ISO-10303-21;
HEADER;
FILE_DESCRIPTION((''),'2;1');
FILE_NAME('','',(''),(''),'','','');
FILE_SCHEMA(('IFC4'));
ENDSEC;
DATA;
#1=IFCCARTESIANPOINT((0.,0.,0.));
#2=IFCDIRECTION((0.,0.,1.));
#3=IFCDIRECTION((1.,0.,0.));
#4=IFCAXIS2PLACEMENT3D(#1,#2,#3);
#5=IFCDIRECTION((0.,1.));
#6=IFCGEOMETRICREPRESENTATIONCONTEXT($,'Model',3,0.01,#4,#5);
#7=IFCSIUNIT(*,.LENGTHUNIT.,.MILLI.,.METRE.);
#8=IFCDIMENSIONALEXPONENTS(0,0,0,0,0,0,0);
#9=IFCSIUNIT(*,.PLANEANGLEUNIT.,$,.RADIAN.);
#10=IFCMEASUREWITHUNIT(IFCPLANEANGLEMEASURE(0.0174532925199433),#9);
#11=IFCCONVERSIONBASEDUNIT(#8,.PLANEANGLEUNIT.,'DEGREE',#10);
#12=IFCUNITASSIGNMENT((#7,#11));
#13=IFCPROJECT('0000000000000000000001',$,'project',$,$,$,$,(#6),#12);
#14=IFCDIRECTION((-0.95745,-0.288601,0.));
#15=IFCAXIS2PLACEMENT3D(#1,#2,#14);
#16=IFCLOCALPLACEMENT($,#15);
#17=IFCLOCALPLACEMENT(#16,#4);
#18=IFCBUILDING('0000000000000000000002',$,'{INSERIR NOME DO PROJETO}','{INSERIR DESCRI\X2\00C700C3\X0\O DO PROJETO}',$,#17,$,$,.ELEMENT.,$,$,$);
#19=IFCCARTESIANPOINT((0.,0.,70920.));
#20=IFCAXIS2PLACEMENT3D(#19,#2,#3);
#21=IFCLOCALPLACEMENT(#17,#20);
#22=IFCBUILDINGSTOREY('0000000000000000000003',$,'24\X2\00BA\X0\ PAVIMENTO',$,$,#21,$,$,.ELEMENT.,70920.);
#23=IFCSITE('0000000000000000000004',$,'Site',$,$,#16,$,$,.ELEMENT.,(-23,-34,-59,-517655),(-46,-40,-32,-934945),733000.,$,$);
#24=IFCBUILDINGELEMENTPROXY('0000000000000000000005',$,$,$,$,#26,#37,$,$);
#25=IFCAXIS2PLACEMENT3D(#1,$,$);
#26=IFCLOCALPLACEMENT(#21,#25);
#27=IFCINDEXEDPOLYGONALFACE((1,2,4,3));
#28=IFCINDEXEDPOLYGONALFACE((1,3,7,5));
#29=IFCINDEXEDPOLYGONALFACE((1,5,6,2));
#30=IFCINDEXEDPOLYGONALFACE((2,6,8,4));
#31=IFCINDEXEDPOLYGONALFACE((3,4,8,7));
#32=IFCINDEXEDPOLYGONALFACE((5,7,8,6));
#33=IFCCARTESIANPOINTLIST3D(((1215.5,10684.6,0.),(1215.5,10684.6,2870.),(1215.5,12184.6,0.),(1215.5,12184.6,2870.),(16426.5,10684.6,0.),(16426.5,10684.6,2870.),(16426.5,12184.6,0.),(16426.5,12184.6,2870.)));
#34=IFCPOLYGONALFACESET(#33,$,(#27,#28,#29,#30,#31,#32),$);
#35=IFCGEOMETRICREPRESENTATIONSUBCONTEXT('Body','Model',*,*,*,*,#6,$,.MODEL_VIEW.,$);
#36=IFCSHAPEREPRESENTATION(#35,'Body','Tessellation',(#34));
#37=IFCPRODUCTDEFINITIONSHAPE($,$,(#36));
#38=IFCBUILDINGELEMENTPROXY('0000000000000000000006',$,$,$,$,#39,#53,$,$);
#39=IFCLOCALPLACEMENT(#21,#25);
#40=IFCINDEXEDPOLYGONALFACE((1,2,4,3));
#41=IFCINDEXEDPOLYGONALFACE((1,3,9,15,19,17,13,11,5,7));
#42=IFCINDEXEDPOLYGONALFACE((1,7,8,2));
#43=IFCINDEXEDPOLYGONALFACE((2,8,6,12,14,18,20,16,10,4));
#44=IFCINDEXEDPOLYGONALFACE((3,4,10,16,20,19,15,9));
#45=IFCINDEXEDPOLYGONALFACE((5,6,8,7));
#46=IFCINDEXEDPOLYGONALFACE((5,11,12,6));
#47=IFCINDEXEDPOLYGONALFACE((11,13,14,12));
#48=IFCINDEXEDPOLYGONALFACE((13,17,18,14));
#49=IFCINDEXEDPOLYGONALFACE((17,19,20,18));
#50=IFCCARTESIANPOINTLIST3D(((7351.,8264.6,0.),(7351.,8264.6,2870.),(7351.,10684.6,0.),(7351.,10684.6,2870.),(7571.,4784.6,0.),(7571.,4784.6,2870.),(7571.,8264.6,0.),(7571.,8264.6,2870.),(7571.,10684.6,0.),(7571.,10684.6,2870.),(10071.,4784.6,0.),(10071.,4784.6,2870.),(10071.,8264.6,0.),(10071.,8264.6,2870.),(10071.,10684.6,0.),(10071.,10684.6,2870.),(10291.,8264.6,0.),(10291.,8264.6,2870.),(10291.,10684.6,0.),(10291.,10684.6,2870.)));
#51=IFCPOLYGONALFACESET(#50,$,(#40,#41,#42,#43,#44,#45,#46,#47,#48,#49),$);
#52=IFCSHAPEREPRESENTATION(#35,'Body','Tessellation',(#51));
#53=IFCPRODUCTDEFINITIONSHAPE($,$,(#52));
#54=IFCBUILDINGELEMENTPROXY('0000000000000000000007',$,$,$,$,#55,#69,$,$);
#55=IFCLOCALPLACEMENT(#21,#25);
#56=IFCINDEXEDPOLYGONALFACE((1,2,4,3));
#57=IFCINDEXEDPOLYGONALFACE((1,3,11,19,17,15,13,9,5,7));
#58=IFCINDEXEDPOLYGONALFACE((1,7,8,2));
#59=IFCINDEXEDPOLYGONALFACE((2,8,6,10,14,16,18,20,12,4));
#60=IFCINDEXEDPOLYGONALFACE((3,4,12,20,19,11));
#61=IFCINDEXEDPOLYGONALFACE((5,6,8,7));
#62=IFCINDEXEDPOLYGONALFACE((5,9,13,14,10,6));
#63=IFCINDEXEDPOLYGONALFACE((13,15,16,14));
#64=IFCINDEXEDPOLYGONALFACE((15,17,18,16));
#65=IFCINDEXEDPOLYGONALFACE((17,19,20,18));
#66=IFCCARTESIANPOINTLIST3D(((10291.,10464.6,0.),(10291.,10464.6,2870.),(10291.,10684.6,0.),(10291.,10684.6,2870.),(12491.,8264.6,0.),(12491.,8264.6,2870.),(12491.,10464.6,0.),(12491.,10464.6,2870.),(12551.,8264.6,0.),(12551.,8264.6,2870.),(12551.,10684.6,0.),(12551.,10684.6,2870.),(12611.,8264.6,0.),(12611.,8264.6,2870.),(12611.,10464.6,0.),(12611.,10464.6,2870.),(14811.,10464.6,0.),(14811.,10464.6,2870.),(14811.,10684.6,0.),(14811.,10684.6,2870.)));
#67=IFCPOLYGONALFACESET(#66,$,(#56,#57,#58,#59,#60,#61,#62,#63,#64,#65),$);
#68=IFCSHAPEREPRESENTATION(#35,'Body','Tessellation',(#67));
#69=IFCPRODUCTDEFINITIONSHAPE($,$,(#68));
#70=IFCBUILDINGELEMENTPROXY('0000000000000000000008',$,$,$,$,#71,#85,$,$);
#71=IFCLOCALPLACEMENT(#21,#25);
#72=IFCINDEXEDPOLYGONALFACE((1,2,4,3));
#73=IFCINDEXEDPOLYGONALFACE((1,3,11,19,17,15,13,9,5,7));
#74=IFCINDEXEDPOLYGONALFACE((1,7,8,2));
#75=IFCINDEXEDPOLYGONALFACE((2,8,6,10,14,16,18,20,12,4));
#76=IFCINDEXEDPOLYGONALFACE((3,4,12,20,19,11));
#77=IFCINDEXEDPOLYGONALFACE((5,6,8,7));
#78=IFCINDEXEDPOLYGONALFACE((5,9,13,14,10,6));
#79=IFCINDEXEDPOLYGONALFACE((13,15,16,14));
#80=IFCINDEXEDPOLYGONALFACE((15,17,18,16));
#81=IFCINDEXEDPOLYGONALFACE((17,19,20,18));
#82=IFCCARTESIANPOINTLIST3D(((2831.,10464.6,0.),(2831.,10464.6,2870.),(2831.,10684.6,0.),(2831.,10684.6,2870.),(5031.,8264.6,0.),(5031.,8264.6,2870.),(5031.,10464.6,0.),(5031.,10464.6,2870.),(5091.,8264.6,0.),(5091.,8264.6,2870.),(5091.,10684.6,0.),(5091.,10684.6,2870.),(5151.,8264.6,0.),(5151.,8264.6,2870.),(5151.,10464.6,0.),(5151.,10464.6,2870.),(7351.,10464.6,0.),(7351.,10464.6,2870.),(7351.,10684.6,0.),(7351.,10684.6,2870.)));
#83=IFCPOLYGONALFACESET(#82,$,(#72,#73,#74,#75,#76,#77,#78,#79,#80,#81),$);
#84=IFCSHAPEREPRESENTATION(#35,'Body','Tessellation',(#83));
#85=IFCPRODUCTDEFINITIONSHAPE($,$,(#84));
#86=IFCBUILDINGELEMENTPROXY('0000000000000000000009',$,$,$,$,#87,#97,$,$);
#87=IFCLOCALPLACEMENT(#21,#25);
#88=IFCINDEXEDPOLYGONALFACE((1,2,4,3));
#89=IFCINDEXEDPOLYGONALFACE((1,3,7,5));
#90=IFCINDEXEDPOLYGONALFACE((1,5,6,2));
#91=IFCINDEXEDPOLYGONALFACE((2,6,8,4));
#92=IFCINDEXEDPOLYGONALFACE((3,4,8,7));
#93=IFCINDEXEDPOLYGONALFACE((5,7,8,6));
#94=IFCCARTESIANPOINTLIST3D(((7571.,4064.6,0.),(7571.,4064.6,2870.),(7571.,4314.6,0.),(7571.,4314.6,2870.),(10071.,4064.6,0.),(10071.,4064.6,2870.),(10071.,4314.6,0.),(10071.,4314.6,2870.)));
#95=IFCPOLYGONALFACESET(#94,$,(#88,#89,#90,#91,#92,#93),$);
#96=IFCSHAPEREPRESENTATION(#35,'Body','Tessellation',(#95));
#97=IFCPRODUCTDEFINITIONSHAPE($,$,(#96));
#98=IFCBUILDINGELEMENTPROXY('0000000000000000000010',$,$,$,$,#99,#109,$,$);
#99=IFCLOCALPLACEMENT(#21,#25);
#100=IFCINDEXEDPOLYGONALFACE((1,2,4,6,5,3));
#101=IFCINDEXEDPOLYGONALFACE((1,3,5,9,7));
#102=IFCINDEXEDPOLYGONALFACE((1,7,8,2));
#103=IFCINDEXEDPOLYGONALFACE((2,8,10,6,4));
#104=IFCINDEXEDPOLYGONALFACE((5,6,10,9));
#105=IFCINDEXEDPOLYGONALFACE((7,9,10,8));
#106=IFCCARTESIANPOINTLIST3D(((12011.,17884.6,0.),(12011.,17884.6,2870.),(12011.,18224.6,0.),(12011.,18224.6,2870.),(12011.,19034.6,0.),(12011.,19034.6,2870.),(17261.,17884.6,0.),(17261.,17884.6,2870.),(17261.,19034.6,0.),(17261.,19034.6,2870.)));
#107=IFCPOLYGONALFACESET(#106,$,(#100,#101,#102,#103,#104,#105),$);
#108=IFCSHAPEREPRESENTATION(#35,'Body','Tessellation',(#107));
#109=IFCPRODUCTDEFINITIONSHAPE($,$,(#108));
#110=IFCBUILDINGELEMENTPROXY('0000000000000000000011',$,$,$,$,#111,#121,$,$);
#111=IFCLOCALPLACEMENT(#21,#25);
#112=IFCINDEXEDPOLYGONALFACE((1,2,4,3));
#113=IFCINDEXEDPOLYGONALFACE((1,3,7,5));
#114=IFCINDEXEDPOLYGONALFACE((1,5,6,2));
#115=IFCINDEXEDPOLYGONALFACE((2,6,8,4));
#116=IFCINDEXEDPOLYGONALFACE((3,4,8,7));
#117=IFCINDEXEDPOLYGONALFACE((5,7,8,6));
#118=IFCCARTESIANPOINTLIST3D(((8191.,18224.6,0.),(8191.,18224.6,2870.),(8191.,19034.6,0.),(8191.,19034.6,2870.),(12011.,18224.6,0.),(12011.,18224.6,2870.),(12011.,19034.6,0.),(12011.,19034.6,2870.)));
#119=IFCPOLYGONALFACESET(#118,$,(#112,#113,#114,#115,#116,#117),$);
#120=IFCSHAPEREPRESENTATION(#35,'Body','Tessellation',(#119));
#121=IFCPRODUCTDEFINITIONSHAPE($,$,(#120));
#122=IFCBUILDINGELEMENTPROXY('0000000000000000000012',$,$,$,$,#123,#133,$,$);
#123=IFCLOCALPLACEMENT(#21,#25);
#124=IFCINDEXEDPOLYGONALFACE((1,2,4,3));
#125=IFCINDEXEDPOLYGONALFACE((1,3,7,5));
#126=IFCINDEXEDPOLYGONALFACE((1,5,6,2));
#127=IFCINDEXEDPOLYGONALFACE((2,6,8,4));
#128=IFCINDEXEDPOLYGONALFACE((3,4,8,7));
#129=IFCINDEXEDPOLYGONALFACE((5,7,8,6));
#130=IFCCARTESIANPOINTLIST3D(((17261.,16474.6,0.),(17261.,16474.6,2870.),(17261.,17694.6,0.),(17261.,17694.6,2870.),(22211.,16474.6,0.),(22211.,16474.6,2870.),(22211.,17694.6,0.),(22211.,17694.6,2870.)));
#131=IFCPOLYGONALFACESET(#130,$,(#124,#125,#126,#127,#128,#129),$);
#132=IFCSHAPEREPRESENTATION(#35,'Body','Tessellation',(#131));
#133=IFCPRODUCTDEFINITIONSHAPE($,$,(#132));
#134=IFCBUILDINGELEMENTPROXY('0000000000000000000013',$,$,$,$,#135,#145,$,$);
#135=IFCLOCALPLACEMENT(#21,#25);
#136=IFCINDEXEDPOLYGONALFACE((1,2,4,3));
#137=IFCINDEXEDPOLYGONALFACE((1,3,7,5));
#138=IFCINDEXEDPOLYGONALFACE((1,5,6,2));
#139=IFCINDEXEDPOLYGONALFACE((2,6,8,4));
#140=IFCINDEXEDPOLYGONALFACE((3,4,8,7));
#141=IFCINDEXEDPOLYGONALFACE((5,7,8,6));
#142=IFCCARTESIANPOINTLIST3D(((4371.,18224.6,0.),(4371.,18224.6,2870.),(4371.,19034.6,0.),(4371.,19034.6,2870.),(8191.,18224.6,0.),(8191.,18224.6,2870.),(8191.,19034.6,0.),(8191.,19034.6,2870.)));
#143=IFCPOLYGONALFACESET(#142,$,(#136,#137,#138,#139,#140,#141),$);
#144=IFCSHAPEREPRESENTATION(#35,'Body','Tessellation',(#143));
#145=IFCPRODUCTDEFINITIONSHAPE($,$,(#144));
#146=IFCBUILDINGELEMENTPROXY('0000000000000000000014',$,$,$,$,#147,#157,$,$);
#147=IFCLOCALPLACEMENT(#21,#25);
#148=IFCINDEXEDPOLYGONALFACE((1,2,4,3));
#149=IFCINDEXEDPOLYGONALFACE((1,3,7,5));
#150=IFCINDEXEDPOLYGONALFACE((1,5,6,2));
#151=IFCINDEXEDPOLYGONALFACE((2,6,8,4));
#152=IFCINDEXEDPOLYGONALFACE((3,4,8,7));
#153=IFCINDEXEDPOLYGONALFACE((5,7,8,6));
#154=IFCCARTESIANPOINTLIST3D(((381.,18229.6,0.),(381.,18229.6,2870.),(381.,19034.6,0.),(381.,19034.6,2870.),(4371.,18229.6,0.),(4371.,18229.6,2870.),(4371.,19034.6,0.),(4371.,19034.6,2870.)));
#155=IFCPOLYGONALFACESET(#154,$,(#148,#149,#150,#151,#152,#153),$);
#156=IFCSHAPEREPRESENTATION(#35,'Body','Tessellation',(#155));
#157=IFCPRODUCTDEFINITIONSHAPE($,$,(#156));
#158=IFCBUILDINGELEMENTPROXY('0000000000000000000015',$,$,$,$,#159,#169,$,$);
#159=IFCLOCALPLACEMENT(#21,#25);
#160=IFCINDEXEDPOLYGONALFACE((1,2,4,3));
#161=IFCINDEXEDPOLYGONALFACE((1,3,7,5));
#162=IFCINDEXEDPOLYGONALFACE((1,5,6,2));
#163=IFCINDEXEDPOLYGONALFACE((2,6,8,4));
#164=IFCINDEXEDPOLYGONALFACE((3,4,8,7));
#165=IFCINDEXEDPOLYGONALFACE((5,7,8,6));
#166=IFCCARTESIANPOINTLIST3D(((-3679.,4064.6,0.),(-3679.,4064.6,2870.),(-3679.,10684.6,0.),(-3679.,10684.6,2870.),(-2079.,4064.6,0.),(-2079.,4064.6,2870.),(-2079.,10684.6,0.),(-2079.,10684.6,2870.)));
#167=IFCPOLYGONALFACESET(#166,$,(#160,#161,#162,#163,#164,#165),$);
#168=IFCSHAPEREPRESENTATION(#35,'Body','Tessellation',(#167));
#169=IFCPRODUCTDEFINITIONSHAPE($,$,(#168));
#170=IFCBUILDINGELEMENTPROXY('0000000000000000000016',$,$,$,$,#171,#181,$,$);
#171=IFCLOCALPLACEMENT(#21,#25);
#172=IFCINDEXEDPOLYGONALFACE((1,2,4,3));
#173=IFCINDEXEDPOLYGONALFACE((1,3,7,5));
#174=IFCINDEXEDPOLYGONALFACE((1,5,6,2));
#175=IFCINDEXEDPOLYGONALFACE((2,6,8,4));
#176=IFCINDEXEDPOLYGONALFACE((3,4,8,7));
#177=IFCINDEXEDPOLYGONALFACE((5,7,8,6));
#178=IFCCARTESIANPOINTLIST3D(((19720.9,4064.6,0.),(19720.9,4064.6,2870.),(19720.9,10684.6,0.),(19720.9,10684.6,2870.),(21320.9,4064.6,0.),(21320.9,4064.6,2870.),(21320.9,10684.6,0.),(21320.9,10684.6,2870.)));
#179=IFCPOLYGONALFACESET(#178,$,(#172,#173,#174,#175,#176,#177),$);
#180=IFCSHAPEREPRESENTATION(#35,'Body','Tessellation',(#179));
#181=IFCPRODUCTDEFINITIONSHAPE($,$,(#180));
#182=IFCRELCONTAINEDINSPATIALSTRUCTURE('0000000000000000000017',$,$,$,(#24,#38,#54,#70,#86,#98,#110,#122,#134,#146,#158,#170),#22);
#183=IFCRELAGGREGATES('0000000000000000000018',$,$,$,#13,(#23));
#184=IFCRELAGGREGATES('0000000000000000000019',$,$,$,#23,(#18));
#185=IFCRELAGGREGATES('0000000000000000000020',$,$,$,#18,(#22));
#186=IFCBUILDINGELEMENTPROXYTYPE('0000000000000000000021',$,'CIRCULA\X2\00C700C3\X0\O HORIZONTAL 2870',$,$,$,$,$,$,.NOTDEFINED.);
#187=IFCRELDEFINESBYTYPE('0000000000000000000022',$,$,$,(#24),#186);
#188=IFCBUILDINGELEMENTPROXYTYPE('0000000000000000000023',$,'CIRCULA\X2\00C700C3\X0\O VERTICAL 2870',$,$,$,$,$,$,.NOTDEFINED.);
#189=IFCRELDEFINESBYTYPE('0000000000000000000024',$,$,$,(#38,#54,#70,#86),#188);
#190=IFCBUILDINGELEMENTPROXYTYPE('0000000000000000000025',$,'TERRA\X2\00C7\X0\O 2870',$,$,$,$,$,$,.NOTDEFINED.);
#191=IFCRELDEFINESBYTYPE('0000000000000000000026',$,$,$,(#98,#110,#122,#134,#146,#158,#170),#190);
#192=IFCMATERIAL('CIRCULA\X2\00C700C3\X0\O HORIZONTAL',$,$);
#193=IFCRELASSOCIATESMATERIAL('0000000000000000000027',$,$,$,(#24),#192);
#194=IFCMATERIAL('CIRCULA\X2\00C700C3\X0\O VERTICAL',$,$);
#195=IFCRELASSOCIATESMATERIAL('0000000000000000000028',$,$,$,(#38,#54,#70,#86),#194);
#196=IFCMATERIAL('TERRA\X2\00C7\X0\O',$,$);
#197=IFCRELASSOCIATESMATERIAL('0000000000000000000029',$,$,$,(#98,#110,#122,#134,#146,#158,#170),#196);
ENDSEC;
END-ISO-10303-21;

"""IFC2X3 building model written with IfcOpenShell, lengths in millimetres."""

from ifc_helpers import new_model, entity, si_unit, converted_unit, direction, frame, origin_with_axes, place, context, subcontext, project, spatial, polyline, outline, extrude, material, type_object, element, save


model = new_model("IFC2X3")

# Units and contexts
model_context = context("Model", 3, precision=0.01, world=origin_with_axes(), true_north=direction((0.0, 1.0)))
body_context = subcontext(model_context, "Body", "Model", "MODEL_VIEW")
ifc_project = project(units=[si_unit("LENGTHUNIT", "METRE", prefix="MILLI"), converted_unit("PLANEANGLEUNIT", "DEGREE", entity("IfcPlaneAngleMeasure", 0.0174532925199433), si_unit("PLANEANGLEUNIT", "RADIAN"), dimensions=[0, 0, 0, 0, 0, 0, 0])], contexts=[model_context])

# Site, building, storey
site_placement = place(None, frame((0.0, 0.0, 0.0), z_axis=(0.0, 0.0, 1.0), x_axis=(-0.95745, -0.288601, 0.0)))
site = spatial("IfcSite", under=ifc_project, at=site_placement, Name="Site", CompositionType="ELEMENT", RefLatitude=(-23, -34, -59, -517655), RefLongitude=(-46, -40, -32, -934945), RefElevation=733000.0)
building_placement = place(site_placement, origin_with_axes())
building = spatial("IfcBuilding", under=site, at=building_placement, Name="{INSERIR NOME DO PROJETO}", Description="{INSERIR DESCRIÇÃO DO PROJETO}", CompositionType="ELEMENT")
storey_placement = place(building_placement, frame((0.0, 0.0, 70920.0), z_axis=(0.0, 0.0, 1.0), x_axis=(1.0, 0.0, 0.0)))
storey = spatial("IfcBuildingStorey", under=building, at=storey_placement, Name="24º PAVIMENTO", CompositionType="ELEMENT", Elevation=70920.0)

# Building element proxies
ifc_material_1 = material(Name="CIRCULAÇÃO HORIZONTAL")
building_element_proxy_type_1 = type_object("IfcBuildingElementProxyType", Name="CIRCULAÇÃO HORIZONTAL 2870", PredefinedType="NOTDEFINED")
proxy_1_placement = place(storey_placement, frame((1215.5, 10684.6, 0.0), z_axis=(0.0, 0.0, 1.0), x_axis=(1.0, 0.0, 0.0)))
element("IfcBuildingElementProxy", 1, at=proxy_1_placement, inside=storey, type_object=building_element_proxy_type_1, material=ifc_material_1, context=body_context, shape_type="SweptSolid", body=[
    extrude(outline(polyline([(0.0, 0.0), (15211.0, 0.0), (15211.0, 1500.0), (0.0, 1500.0), (0.0, 0.0)])), origin_with_axes(), (0.0, 0.0, 1.0), 2870.0),
])
ifc_material_2 = material(Name="CIRCULAÇÃO VERTICAL")
building_element_proxy_type_2 = type_object("IfcBuildingElementProxyType", Name="CIRCULAÇÃO VERTICAL 2870", PredefinedType="NOTDEFINED")
proxy_2_placement = place(storey_placement, frame((7351.0, 10684.6, 0.0), z_axis=(0.0, 0.0, 1.0), x_axis=(1.0, 0.0, 0.0)))
element("IfcBuildingElementProxy", 2, at=proxy_2_placement, inside=storey, type_object=building_element_proxy_type_2, material=ifc_material_2, context=body_context, shape_type="SweptSolid", body=[
    extrude(outline(polyline([(0.0, 0.0), (0.0, -2420.0), (220.0, -2420.0), (220.0, -5900.0), (2720.0, -5900.0), (2720.0, -2420.0), (2940.0, -2420.0), (2940.0, 0.0), (2720.0, 0.0), (220.0, 0.0), (0.0, 0.0)])), origin_with_axes(), (0.0, 0.0, 1.0), 2870.0),
])
proxy_3_placement = place(storey_placement, frame((10291.0, 10684.6, 0.0), z_axis=(0.0, 0.0, 1.0), x_axis=(1.0, 0.0, 0.0)))
element("IfcBuildingElementProxy", 3, at=proxy_3_placement, inside=storey, type_object=building_element_proxy_type_2, material=ifc_material_2, context=body_context, shape_type="SweptSolid", body=[
    extrude(outline(polyline([(0.0, 0.0), (0.0, -220.0), (2200.0, -220.0), (2200.0, -2420.0), (2260.0, -2420.0), (2320.0, -2420.0), (2320.0, -220.0), (4520.0, -220.0), (4520.0, 0.0), (2260.0, 0.0), (0.0, 0.0)])), origin_with_axes(), (0.0, 0.0, 1.0), 2870.0),
])
proxy_4_placement = place(storey_placement, frame((5091.0, 10684.6, 0.0), z_axis=(0.0, 0.0, 1.0), x_axis=(1.0, 0.0, 0.0)))
element("IfcBuildingElementProxy", 4, at=proxy_4_placement, inside=storey, type_object=building_element_proxy_type_2, material=ifc_material_2, context=body_context, shape_type="SweptSolid", body=[
    extrude(outline(polyline([(0.0, 0.0), (-2260.0, 0.0), (-2260.0, -220.0), (-60.0, -220.0), (-60.0, -2420.0), (0.0, -2420.0), (60.0, -2420.0), (60.0, -220.0), (2260.0, -220.0), (2260.0, 0.0), (0.0, 0.0)])), origin_with_axes(), (0.0, 0.0, 1.0), 2870.0),
])
proxy_5_placement = place(storey_placement, frame((7571.0, 4064.6, 0.0), z_axis=(0.0, 0.0, 1.0), x_axis=(1.0, 0.0, 0.0)))
element("IfcBuildingElementProxy", 5, at=proxy_5_placement, inside=storey, type_object=building_element_proxy_type_2, material=ifc_material_2, context=body_context, shape_type="SweptSolid", body=[
    extrude(outline(polyline([(0.0, 0.0), (2500.0, 0.0), (2500.0, 250.0), (0.0, 250.0), (0.0, 0.0)])), origin_with_axes(), (0.0, 0.0, 1.0), 2870.0),
])
ifc_material_3 = material(Name="TERRAÇO")
building_element_proxy_type_3 = type_object("IfcBuildingElementProxyType", Name="TERRAÇO 2870", PredefinedType="NOTDEFINED")
proxy_6_placement = place(storey_placement, frame((12011.0, 19034.6, 0.0), z_axis=(0.0, 0.0, 1.0), x_axis=(1.0, 0.0, 0.0)))
element("IfcBuildingElementProxy", 6, at=proxy_6_placement, inside=storey, type_object=building_element_proxy_type_3, material=ifc_material_3, context=body_context, shape_type="SweptSolid", body=[
    extrude(outline(polyline([(0.0, 0.0), (0.0, -810.0), (0.0, -1150.0), (5250.0, -1150.0), (5250.0, 0.0), (0.0, 0.0)])), origin_with_axes(), (0.0, 0.0, 1.0), 2870.0),
])
proxy_7_placement = place(storey_placement, frame((8191.0, 18224.6, 0.0), z_axis=(0.0, 0.0, 1.0), x_axis=(1.0, 0.0, 0.0)))
element("IfcBuildingElementProxy", 7, at=proxy_7_placement, inside=storey, type_object=building_element_proxy_type_3, material=ifc_material_3, context=body_context, shape_type="SweptSolid", body=[
    extrude(outline(polyline([(0.0, 0.0), (3820.0, 0.0), (3820.0, 810.0), (0.0, 810.0), (0.0, 0.0)])), origin_with_axes(), (0.0, 0.0, 1.0), 2870.0),
])
proxy_8_placement = place(storey_placement, frame((17261.0, 16474.6, 0.0), z_axis=(0.0, 0.0, 1.0), x_axis=(1.0, 0.0, 0.0)))
element("IfcBuildingElementProxy", 8, at=proxy_8_placement, inside=storey, type_object=building_element_proxy_type_3, material=ifc_material_3, context=body_context, shape_type="SweptSolid", body=[
    extrude(outline(polyline([(0.0, 0.0), (4950.0, 0.0), (4950.0, 1220.0), (0.0, 1220.0), (0.0, 0.0)])), origin_with_axes(), (0.0, 0.0, 1.0), 2870.0),
])
proxy_9_placement = place(storey_placement, frame((4371.0, 18224.6, 0.0), z_axis=(0.0, 0.0, 1.0), x_axis=(1.0, 0.0, 0.0)))
element("IfcBuildingElementProxy", 9, at=proxy_9_placement, inside=storey, type_object=building_element_proxy_type_3, material=ifc_material_3, context=body_context, shape_type="SweptSolid", body=[
    extrude(outline(polyline([(0.0, 0.0), (3820.0, 0.0), (3820.0, 810.0), (0.0, 810.0), (0.0, 0.0)])), origin_with_axes(), (0.0, 0.0, 1.0), 2870.0),
])
proxy_10_placement = place(storey_placement, frame((381.0, 19034.6, 0.0), z_axis=(0.0, 0.0, 1.0), x_axis=(1.0, 0.0, 0.0)))
element("IfcBuildingElementProxy", 10, at=proxy_10_placement, inside=storey, type_object=building_element_proxy_type_3, material=ifc_material_3, context=body_context, shape_type="SweptSolid", body=[
    extrude(outline(polyline([(0.0, 0.0), (0.0, -805.0), (3990.0, -805.0), (3990.0, 0.0), (0.0, 0.0)])), origin_with_axes(), (0.0, 0.0, 1.0), 2870.0),
])
proxy_11_placement = place(storey_placement, frame((-3679.0, 4064.6, 0.0), z_axis=(0.0, 0.0, 1.0), x_axis=(1.0, 0.0, 0.0)))
element("IfcBuildingElementProxy", 11, at=proxy_11_placement, inside=storey, type_object=building_element_proxy_type_3, material=ifc_material_3, context=body_context, shape_type="SweptSolid", body=[
    extrude(outline(polyline([(0.0, 0.0), (1600.0, 0.0), (1600.0, 6620.0), (0.0, 6620.0), (0.0, 0.0)])), origin_with_axes(), (0.0, 0.0, 1.0), 2870.0),
])
proxy_12_placement = place(storey_placement, frame((21320.9, 4064.6, 0.0), z_axis=(0.0, 0.0, 1.0), x_axis=(1.0, 0.0, 0.0)))
element("IfcBuildingElementProxy", 12, at=proxy_12_placement, inside=storey, type_object=building_element_proxy_type_3, material=ifc_material_3, context=body_context, shape_type="SweptSolid", body=[
    extrude(outline(polyline([(0.0, 0.0), (0.0, 6620.0), (-1600.0, 6620.0), (-1600.0, 0.0), (0.0, 0.0)])), origin_with_axes(), (0.0, 0.0, 1.0), 2870.0),
])

save(model, "model.ifc")
